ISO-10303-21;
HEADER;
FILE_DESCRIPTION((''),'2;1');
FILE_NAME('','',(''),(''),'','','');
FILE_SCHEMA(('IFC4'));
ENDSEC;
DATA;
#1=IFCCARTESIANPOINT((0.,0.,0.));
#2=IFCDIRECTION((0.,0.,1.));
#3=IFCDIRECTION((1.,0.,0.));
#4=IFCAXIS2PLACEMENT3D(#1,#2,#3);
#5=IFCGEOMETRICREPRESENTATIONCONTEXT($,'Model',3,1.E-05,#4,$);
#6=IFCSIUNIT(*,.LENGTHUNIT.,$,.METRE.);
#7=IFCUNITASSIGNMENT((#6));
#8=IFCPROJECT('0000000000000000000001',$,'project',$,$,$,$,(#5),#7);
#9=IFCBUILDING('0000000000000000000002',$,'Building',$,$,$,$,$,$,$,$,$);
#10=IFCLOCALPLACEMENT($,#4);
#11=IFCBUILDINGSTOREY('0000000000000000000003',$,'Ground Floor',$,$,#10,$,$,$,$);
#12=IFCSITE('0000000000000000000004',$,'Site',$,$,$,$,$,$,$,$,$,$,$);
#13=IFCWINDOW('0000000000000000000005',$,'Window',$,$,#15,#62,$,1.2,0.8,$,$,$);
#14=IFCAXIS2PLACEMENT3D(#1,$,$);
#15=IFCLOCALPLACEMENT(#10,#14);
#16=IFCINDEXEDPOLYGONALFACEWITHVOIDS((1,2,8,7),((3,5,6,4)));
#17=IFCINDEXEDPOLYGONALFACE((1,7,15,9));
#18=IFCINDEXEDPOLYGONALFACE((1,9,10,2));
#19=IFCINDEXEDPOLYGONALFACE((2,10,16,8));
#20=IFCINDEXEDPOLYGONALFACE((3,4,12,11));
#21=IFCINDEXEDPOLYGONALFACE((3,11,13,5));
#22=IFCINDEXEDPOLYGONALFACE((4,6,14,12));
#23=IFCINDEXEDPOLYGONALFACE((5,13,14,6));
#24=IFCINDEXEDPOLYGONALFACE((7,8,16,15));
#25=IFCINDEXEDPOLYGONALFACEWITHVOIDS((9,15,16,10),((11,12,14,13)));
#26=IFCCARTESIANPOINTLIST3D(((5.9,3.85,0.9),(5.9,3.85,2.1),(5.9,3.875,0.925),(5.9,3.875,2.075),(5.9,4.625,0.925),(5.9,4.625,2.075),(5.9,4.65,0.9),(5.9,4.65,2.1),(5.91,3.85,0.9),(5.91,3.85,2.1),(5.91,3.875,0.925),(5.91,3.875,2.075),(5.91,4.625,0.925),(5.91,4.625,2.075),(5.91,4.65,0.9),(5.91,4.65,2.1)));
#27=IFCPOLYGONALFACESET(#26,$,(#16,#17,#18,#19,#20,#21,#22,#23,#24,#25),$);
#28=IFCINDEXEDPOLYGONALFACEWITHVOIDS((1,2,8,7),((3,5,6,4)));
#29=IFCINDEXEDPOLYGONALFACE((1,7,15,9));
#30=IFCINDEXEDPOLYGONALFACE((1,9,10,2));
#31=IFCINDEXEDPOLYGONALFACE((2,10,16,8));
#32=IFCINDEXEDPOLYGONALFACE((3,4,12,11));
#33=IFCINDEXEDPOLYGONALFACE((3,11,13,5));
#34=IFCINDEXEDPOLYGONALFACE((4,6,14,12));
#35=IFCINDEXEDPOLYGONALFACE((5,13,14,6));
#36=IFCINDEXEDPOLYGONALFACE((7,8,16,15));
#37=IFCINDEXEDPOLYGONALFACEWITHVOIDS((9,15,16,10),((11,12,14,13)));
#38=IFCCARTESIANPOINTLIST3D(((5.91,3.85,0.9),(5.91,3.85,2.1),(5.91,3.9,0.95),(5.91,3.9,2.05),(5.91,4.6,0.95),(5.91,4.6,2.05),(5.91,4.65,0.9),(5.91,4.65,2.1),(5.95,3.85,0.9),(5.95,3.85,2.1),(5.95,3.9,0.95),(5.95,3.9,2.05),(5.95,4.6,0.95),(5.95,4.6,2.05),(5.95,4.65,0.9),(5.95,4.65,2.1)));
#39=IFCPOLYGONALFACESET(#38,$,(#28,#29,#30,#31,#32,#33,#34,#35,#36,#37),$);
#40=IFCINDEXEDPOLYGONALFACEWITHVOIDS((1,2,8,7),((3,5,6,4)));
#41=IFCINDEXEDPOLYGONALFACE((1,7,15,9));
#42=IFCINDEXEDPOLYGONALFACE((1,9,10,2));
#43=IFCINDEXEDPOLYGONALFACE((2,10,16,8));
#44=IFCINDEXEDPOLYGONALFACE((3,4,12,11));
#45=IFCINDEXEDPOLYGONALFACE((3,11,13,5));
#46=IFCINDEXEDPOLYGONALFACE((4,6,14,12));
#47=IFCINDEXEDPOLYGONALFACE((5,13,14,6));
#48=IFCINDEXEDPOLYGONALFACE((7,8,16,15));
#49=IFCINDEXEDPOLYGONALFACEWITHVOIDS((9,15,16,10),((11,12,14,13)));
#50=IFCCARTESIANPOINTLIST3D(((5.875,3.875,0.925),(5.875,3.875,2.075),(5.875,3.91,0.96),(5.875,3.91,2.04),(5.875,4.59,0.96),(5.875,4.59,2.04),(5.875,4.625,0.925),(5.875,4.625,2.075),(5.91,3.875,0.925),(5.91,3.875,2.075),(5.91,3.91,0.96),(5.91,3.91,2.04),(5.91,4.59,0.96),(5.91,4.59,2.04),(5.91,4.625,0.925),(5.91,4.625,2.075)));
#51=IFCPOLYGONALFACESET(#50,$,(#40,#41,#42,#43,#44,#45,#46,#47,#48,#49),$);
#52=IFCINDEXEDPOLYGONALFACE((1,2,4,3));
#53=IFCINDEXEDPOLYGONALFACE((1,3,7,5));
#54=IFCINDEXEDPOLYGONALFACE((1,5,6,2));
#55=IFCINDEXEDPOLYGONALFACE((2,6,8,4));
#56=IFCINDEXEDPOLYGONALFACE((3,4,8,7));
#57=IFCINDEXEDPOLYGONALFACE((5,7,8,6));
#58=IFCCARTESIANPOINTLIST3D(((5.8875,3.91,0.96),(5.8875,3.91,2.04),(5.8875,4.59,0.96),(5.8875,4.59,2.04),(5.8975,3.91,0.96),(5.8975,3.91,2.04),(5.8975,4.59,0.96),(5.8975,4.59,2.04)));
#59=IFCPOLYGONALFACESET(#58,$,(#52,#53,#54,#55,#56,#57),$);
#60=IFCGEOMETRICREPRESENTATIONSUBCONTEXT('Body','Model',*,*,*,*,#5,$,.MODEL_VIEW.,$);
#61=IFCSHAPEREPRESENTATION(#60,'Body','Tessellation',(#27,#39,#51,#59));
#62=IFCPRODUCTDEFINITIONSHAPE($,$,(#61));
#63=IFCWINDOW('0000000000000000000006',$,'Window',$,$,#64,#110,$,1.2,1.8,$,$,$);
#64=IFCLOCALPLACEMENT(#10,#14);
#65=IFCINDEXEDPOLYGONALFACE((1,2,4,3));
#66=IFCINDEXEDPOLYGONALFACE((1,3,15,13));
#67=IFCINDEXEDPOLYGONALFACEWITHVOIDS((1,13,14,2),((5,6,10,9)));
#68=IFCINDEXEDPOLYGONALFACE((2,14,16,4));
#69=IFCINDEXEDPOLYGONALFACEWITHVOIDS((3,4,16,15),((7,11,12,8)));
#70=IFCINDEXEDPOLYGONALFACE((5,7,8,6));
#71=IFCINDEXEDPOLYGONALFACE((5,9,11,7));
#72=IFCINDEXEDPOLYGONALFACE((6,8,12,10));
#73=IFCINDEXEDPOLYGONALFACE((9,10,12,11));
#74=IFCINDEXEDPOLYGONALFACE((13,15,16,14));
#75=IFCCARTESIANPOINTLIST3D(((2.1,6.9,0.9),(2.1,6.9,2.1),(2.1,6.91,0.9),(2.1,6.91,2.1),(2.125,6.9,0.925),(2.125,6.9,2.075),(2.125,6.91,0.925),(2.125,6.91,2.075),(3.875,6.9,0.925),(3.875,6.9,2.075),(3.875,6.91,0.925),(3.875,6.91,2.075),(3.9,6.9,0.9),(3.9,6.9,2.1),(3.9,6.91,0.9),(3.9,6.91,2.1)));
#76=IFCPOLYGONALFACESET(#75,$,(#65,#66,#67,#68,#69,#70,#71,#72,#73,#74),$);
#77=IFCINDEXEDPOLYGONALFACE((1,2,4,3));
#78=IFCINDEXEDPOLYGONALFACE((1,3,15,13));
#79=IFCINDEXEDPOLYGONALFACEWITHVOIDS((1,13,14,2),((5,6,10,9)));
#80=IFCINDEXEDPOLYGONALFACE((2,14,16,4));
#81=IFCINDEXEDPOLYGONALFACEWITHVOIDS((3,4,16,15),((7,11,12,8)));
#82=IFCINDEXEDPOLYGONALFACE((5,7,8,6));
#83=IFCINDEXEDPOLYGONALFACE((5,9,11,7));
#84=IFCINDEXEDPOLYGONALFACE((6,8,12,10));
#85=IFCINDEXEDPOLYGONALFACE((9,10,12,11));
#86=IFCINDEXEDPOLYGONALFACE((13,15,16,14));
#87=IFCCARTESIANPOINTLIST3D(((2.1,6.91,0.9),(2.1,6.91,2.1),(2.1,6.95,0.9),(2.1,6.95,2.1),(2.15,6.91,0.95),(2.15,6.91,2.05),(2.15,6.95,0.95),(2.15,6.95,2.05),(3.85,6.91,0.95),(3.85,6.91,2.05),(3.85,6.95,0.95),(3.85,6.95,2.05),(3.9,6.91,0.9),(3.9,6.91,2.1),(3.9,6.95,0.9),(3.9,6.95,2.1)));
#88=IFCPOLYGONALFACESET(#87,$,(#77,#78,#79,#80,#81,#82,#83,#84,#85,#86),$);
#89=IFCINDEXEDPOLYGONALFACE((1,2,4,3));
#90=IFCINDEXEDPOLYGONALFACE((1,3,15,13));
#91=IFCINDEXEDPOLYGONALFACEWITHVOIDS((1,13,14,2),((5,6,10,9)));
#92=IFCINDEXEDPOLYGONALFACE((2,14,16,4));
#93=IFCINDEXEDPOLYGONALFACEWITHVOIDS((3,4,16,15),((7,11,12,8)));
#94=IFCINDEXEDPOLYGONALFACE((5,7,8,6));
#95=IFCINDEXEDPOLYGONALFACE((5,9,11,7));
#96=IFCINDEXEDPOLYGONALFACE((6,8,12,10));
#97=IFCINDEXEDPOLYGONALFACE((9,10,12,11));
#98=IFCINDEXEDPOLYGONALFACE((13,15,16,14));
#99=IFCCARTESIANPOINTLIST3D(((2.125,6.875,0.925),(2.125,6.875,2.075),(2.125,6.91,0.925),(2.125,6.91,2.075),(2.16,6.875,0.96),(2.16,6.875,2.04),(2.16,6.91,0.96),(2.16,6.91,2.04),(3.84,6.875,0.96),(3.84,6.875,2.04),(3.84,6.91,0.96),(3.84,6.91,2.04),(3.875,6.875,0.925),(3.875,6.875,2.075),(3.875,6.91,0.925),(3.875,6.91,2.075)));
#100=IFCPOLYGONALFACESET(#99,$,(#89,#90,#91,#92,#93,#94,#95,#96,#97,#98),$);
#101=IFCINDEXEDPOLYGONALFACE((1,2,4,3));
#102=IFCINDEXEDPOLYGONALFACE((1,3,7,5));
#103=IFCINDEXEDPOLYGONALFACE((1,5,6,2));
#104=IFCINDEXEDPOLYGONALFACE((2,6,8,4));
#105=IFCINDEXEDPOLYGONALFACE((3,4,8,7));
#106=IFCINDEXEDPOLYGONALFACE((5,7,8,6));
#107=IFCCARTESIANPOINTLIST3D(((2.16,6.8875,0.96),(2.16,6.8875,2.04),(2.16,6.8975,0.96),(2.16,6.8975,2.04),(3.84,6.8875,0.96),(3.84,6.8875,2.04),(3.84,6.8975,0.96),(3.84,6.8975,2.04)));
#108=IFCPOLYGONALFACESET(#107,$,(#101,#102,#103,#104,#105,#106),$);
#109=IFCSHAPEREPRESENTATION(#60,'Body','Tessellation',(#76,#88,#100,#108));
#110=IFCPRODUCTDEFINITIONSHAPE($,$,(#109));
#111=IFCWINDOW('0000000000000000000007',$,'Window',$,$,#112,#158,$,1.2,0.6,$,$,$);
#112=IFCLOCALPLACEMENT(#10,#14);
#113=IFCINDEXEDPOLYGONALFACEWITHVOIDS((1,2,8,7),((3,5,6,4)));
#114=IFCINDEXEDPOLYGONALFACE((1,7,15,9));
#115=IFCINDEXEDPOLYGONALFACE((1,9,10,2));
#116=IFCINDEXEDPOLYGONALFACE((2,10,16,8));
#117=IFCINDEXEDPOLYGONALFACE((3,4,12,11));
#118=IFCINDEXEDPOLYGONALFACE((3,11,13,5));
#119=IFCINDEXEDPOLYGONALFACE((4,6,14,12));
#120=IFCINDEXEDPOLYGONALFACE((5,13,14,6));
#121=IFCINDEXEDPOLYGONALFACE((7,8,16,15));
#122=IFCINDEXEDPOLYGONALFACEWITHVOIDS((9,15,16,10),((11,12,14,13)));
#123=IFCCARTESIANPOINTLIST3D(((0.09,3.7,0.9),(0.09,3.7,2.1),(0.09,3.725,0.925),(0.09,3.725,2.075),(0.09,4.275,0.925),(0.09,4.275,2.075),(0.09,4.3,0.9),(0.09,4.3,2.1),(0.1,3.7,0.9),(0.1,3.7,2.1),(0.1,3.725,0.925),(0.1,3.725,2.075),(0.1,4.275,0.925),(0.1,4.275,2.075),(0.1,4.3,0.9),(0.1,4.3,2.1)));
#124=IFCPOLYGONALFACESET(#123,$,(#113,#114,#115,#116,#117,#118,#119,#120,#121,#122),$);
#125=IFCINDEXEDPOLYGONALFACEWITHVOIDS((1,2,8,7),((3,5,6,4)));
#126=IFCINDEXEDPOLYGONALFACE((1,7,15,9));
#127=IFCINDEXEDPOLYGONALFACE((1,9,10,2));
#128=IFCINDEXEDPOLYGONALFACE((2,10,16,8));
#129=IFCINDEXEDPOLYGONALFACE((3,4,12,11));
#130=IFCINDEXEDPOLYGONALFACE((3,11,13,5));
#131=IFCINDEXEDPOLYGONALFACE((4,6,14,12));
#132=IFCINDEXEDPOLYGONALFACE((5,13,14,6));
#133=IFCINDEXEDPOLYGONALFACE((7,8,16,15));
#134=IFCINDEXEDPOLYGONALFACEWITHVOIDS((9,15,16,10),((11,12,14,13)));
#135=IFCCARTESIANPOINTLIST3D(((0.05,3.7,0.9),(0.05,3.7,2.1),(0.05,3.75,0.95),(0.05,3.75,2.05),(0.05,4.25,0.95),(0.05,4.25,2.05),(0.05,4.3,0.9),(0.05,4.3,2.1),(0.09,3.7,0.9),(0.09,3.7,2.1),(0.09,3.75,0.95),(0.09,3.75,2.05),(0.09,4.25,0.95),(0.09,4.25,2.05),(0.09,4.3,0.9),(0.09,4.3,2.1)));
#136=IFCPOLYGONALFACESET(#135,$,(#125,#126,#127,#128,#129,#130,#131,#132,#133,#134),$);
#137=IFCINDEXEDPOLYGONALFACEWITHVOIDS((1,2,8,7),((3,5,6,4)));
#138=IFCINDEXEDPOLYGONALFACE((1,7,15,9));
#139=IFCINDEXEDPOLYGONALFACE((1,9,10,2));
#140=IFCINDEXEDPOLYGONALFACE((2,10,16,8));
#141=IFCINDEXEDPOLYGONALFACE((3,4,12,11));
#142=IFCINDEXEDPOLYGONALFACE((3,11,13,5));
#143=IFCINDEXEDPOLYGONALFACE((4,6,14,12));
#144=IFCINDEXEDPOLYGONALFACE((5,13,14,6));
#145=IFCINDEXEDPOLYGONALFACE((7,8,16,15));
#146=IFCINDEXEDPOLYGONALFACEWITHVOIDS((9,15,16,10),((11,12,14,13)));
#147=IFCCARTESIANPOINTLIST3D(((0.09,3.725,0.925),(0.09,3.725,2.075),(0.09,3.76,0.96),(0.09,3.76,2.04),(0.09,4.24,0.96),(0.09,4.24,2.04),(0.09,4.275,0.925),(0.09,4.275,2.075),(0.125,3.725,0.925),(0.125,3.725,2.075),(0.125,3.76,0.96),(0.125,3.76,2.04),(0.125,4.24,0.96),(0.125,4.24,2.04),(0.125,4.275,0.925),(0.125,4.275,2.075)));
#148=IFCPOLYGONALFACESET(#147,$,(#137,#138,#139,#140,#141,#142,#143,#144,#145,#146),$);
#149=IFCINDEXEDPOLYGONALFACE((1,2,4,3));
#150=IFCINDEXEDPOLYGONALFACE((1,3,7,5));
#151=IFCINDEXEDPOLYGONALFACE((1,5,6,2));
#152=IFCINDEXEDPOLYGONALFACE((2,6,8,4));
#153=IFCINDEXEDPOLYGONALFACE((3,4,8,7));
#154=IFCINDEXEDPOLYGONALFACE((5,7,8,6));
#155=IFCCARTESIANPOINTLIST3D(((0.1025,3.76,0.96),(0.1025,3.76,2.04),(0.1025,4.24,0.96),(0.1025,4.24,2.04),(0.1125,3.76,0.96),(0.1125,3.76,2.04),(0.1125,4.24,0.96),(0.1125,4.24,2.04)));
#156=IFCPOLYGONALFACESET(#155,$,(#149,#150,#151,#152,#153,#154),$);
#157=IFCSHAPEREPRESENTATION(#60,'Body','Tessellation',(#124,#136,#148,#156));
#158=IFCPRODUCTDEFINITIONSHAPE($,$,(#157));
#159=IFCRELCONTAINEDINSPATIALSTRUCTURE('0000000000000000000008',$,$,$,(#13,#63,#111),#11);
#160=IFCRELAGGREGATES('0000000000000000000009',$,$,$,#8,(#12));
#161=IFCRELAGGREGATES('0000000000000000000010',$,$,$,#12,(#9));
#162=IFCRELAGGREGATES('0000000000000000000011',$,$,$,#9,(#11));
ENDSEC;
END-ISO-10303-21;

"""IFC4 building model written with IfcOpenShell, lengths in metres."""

from ifc_helpers import new_model, si_unit, frame, origin_with_axes, place, context, subcontext, project, spatial, line, indexed_curve, outline, extrude, element, save


model = new_model("IFC4")

# Units and contexts
model_context = context("Model", 3, precision=1e-05, world=origin_with_axes())
body_context = subcontext(model_context, "Body", "Model", "MODEL_VIEW")
ifc_project = project(units=[si_unit("LENGTHUNIT", "METRE")], contexts=[model_context])

# Site, building, storey
site = spatial("IfcSite", under=ifc_project, Name="Site")
building = spatial("IfcBuilding", under=site, Name="Building")
storey_placement = place(None, origin_with_axes())
storey = spatial("IfcBuildingStorey", under=building, at=storey_placement, Name="Ground Floor")

# Windows
window_1_placement = place(storey_placement, frame((6.0, 3.85, 0.9), z_axis=(0.0, 0.0, 1.0), x_axis=(0.0, 1.0, 0.0)))
element("IfcWindow", 1, at=window_1_placement, inside=storey, Name="Window", OverallHeight=1.2, OverallWidth=0.8, context=body_context, shape_type="SweptSolid", body=[
    extrude(outline(indexed_curve([(0.0, 0.0), (0.8, 0.0), (0.8, 1.2), (0.0, 1.2)], segments=[line(1, 2, 3, 4, 1)]), holes=[indexed_curve([(0.025, 0.025), (0.775, 0.025), (0.775, 1.175), (0.025, 1.175)], segments=[line(1, 2, 3, 4, 1)])]), frame((0.0, 0.09, 0.0), z_axis=(0.0, -1.0, 0.0), x_axis=(1.0, 0.0, 0.0)), (0.0, 0.0, -1.0), 0.01),
    extrude(outline(indexed_curve([(0.0, 0.0), (0.8, 0.0), (0.8, 1.2), (0.0, 1.2)], segments=[line(1, 2, 3, 4, 1)]), holes=[indexed_curve([(0.05, 0.05), (0.75, 0.05), (0.75, 1.15), (0.05, 1.15)], segments=[line(1, 2, 3, 4, 1)])]), frame((0.0, 0.05, 0.0), z_axis=(0.0, -1.0, 0.0), x_axis=(1.0, 0.0, 0.0)), (0.0, 0.0, -1.0), 0.04),
    extrude(outline(indexed_curve([(0.0, 0.0), (0.75, 0.0), (0.75, 1.15), (0.0, 1.15)], segments=[line(1, 2, 3, 4, 1)]), holes=[indexed_curve([(0.035, 0.035), (0.715, 0.035), (0.715, 1.115), (0.035, 1.115)], segments=[line(1, 2, 3, 4, 1)])]), frame((0.025, 0.09, 0.025), z_axis=(0.0, -1.0, 0.0), x_axis=(1.0, 0.0, 0.0)), (0.0, 0.0, -1.0), 0.035),
    extrude(outline(indexed_curve([(0.035, 0.035), (0.715, 0.035), (0.715, 1.115), (0.035, 1.115)], segments=[line(1, 2, 3, 4, 1)])), frame((0.025, 0.1025, 0.025), z_axis=(0.0, -1.0, 0.0), x_axis=(1.0, 0.0, 0.0)), (0.0, 0.0, -1.0), 0.01),
])
window_2_placement = place(storey_placement, frame((3.9, 7.0, 0.9), z_axis=(0.0, 0.0, 1.0), x_axis=(-1.0, 0.0, 0.0)))
element("IfcWindow", 2, at=window_2_placement, inside=storey, Name="Window", OverallHeight=1.2, OverallWidth=1.8, context=body_context, shape_type="SweptSolid", body=[
    extrude(outline(indexed_curve([(0.0, 0.0), (1.8, 0.0), (1.8, 1.2), (0.0, 1.2)], segments=[line(1, 2, 3, 4, 1)]), holes=[indexed_curve([(0.025, 0.025), (1.775, 0.025), (1.775, 1.175), (0.025, 1.175)], segments=[line(1, 2, 3, 4, 1)])]), frame((0.0, 0.09, 0.0), z_axis=(0.0, -1.0, 0.0), x_axis=(1.0, 0.0, 0.0)), (0.0, 0.0, -1.0), 0.01),
    extrude(outline(indexed_curve([(0.0, 0.0), (1.8, 0.0), (1.8, 1.2), (0.0, 1.2)], segments=[line(1, 2, 3, 4, 1)]), holes=[indexed_curve([(0.05, 0.05), (1.75, 0.05), (1.75, 1.15), (0.05, 1.15)], segments=[line(1, 2, 3, 4, 1)])]), frame((0.0, 0.05, 0.0), z_axis=(0.0, -1.0, 0.0), x_axis=(1.0, 0.0, 0.0)), (0.0, 0.0, -1.0), 0.04),
    extrude(outline(indexed_curve([(0.0, 0.0), (1.75, 0.0), (1.75, 1.15), (0.0, 1.15)], segments=[line(1, 2, 3, 4, 1)]), holes=[indexed_curve([(0.035, 0.035), (1.715, 0.035), (1.715, 1.115), (0.035, 1.115)], segments=[line(1, 2, 3, 4, 1)])]), frame((0.025, 0.09, 0.025), z_axis=(0.0, -1.0, 0.0), x_axis=(1.0, 0.0, 0.0)), (0.0, 0.0, -1.0), 0.035),
    extrude(outline(indexed_curve([(0.035, 0.035), (1.715, 0.035), (1.715, 1.115), (0.035, 1.115)], segments=[line(1, 2, 3, 4, 1)])), frame((0.025, 0.1025, 0.025), z_axis=(0.0, -1.0, 0.0), x_axis=(1.0, 0.0, 0.0)), (0.0, 0.0, -1.0), 0.01),
])
window_3_placement = place(storey_placement, frame((0.0, 4.3, 0.9), z_axis=(0.0, 0.0, 1.0), x_axis=(0.0, -1.0, 0.0)))
element("IfcWindow", 3, at=window_3_placement, inside=storey, Name="Window", OverallHeight=1.2, OverallWidth=0.6, context=body_context, shape_type="SweptSolid", body=[
    extrude(outline(indexed_curve([(0.0, 0.0), (0.6, 0.0), (0.6, 1.2), (0.0, 1.2)], segments=[line(1, 2, 3, 4, 1)]), holes=[indexed_curve([(0.025, 0.025), (0.575, 0.025), (0.575, 1.175), (0.025, 1.175)], segments=[line(1, 2, 3, 4, 1)])]), frame((0.0, 0.09, 0.0), z_axis=(0.0, -1.0, 0.0), x_axis=(1.0, 0.0, 0.0)), (0.0, 0.0, -1.0), 0.01),
    extrude(outline(indexed_curve([(0.0, 0.0), (0.6, 0.0), (0.6, 1.2), (0.0, 1.2)], segments=[line(1, 2, 3, 4, 1)]), holes=[indexed_curve([(0.05, 0.05), (0.55, 0.05), (0.55, 1.15), (0.05, 1.15)], segments=[line(1, 2, 3, 4, 1)])]), frame((0.0, 0.05, 0.0), z_axis=(0.0, -1.0, 0.0), x_axis=(1.0, 0.0, 0.0)), (0.0, 0.0, -1.0), 0.04),
    extrude(outline(indexed_curve([(0.0, 0.0), (0.55, 0.0), (0.55, 1.15), (0.0, 1.15)], segments=[line(1, 2, 3, 4, 1)]), holes=[indexed_curve([(0.035, 0.035), (0.515, 0.035), (0.515, 1.115), (0.035, 1.115)], segments=[line(1, 2, 3, 4, 1)])]), frame((0.025, 0.09, 0.025), z_axis=(0.0, -1.0, 0.0), x_axis=(1.0, 0.0, 0.0)), (0.0, 0.0, -1.0), 0.035),
    extrude(outline(indexed_curve([(0.035, 0.035), (0.515, 0.035), (0.515, 1.115), (0.035, 1.115)], segments=[line(1, 2, 3, 4, 1)])), frame((0.025, 0.1025, 0.025), z_axis=(0.0, -1.0, 0.0), x_axis=(1.0, 0.0, 0.0)), (0.0, 0.0, -1.0), 0.01),
])

save(model, "model.ifc")
